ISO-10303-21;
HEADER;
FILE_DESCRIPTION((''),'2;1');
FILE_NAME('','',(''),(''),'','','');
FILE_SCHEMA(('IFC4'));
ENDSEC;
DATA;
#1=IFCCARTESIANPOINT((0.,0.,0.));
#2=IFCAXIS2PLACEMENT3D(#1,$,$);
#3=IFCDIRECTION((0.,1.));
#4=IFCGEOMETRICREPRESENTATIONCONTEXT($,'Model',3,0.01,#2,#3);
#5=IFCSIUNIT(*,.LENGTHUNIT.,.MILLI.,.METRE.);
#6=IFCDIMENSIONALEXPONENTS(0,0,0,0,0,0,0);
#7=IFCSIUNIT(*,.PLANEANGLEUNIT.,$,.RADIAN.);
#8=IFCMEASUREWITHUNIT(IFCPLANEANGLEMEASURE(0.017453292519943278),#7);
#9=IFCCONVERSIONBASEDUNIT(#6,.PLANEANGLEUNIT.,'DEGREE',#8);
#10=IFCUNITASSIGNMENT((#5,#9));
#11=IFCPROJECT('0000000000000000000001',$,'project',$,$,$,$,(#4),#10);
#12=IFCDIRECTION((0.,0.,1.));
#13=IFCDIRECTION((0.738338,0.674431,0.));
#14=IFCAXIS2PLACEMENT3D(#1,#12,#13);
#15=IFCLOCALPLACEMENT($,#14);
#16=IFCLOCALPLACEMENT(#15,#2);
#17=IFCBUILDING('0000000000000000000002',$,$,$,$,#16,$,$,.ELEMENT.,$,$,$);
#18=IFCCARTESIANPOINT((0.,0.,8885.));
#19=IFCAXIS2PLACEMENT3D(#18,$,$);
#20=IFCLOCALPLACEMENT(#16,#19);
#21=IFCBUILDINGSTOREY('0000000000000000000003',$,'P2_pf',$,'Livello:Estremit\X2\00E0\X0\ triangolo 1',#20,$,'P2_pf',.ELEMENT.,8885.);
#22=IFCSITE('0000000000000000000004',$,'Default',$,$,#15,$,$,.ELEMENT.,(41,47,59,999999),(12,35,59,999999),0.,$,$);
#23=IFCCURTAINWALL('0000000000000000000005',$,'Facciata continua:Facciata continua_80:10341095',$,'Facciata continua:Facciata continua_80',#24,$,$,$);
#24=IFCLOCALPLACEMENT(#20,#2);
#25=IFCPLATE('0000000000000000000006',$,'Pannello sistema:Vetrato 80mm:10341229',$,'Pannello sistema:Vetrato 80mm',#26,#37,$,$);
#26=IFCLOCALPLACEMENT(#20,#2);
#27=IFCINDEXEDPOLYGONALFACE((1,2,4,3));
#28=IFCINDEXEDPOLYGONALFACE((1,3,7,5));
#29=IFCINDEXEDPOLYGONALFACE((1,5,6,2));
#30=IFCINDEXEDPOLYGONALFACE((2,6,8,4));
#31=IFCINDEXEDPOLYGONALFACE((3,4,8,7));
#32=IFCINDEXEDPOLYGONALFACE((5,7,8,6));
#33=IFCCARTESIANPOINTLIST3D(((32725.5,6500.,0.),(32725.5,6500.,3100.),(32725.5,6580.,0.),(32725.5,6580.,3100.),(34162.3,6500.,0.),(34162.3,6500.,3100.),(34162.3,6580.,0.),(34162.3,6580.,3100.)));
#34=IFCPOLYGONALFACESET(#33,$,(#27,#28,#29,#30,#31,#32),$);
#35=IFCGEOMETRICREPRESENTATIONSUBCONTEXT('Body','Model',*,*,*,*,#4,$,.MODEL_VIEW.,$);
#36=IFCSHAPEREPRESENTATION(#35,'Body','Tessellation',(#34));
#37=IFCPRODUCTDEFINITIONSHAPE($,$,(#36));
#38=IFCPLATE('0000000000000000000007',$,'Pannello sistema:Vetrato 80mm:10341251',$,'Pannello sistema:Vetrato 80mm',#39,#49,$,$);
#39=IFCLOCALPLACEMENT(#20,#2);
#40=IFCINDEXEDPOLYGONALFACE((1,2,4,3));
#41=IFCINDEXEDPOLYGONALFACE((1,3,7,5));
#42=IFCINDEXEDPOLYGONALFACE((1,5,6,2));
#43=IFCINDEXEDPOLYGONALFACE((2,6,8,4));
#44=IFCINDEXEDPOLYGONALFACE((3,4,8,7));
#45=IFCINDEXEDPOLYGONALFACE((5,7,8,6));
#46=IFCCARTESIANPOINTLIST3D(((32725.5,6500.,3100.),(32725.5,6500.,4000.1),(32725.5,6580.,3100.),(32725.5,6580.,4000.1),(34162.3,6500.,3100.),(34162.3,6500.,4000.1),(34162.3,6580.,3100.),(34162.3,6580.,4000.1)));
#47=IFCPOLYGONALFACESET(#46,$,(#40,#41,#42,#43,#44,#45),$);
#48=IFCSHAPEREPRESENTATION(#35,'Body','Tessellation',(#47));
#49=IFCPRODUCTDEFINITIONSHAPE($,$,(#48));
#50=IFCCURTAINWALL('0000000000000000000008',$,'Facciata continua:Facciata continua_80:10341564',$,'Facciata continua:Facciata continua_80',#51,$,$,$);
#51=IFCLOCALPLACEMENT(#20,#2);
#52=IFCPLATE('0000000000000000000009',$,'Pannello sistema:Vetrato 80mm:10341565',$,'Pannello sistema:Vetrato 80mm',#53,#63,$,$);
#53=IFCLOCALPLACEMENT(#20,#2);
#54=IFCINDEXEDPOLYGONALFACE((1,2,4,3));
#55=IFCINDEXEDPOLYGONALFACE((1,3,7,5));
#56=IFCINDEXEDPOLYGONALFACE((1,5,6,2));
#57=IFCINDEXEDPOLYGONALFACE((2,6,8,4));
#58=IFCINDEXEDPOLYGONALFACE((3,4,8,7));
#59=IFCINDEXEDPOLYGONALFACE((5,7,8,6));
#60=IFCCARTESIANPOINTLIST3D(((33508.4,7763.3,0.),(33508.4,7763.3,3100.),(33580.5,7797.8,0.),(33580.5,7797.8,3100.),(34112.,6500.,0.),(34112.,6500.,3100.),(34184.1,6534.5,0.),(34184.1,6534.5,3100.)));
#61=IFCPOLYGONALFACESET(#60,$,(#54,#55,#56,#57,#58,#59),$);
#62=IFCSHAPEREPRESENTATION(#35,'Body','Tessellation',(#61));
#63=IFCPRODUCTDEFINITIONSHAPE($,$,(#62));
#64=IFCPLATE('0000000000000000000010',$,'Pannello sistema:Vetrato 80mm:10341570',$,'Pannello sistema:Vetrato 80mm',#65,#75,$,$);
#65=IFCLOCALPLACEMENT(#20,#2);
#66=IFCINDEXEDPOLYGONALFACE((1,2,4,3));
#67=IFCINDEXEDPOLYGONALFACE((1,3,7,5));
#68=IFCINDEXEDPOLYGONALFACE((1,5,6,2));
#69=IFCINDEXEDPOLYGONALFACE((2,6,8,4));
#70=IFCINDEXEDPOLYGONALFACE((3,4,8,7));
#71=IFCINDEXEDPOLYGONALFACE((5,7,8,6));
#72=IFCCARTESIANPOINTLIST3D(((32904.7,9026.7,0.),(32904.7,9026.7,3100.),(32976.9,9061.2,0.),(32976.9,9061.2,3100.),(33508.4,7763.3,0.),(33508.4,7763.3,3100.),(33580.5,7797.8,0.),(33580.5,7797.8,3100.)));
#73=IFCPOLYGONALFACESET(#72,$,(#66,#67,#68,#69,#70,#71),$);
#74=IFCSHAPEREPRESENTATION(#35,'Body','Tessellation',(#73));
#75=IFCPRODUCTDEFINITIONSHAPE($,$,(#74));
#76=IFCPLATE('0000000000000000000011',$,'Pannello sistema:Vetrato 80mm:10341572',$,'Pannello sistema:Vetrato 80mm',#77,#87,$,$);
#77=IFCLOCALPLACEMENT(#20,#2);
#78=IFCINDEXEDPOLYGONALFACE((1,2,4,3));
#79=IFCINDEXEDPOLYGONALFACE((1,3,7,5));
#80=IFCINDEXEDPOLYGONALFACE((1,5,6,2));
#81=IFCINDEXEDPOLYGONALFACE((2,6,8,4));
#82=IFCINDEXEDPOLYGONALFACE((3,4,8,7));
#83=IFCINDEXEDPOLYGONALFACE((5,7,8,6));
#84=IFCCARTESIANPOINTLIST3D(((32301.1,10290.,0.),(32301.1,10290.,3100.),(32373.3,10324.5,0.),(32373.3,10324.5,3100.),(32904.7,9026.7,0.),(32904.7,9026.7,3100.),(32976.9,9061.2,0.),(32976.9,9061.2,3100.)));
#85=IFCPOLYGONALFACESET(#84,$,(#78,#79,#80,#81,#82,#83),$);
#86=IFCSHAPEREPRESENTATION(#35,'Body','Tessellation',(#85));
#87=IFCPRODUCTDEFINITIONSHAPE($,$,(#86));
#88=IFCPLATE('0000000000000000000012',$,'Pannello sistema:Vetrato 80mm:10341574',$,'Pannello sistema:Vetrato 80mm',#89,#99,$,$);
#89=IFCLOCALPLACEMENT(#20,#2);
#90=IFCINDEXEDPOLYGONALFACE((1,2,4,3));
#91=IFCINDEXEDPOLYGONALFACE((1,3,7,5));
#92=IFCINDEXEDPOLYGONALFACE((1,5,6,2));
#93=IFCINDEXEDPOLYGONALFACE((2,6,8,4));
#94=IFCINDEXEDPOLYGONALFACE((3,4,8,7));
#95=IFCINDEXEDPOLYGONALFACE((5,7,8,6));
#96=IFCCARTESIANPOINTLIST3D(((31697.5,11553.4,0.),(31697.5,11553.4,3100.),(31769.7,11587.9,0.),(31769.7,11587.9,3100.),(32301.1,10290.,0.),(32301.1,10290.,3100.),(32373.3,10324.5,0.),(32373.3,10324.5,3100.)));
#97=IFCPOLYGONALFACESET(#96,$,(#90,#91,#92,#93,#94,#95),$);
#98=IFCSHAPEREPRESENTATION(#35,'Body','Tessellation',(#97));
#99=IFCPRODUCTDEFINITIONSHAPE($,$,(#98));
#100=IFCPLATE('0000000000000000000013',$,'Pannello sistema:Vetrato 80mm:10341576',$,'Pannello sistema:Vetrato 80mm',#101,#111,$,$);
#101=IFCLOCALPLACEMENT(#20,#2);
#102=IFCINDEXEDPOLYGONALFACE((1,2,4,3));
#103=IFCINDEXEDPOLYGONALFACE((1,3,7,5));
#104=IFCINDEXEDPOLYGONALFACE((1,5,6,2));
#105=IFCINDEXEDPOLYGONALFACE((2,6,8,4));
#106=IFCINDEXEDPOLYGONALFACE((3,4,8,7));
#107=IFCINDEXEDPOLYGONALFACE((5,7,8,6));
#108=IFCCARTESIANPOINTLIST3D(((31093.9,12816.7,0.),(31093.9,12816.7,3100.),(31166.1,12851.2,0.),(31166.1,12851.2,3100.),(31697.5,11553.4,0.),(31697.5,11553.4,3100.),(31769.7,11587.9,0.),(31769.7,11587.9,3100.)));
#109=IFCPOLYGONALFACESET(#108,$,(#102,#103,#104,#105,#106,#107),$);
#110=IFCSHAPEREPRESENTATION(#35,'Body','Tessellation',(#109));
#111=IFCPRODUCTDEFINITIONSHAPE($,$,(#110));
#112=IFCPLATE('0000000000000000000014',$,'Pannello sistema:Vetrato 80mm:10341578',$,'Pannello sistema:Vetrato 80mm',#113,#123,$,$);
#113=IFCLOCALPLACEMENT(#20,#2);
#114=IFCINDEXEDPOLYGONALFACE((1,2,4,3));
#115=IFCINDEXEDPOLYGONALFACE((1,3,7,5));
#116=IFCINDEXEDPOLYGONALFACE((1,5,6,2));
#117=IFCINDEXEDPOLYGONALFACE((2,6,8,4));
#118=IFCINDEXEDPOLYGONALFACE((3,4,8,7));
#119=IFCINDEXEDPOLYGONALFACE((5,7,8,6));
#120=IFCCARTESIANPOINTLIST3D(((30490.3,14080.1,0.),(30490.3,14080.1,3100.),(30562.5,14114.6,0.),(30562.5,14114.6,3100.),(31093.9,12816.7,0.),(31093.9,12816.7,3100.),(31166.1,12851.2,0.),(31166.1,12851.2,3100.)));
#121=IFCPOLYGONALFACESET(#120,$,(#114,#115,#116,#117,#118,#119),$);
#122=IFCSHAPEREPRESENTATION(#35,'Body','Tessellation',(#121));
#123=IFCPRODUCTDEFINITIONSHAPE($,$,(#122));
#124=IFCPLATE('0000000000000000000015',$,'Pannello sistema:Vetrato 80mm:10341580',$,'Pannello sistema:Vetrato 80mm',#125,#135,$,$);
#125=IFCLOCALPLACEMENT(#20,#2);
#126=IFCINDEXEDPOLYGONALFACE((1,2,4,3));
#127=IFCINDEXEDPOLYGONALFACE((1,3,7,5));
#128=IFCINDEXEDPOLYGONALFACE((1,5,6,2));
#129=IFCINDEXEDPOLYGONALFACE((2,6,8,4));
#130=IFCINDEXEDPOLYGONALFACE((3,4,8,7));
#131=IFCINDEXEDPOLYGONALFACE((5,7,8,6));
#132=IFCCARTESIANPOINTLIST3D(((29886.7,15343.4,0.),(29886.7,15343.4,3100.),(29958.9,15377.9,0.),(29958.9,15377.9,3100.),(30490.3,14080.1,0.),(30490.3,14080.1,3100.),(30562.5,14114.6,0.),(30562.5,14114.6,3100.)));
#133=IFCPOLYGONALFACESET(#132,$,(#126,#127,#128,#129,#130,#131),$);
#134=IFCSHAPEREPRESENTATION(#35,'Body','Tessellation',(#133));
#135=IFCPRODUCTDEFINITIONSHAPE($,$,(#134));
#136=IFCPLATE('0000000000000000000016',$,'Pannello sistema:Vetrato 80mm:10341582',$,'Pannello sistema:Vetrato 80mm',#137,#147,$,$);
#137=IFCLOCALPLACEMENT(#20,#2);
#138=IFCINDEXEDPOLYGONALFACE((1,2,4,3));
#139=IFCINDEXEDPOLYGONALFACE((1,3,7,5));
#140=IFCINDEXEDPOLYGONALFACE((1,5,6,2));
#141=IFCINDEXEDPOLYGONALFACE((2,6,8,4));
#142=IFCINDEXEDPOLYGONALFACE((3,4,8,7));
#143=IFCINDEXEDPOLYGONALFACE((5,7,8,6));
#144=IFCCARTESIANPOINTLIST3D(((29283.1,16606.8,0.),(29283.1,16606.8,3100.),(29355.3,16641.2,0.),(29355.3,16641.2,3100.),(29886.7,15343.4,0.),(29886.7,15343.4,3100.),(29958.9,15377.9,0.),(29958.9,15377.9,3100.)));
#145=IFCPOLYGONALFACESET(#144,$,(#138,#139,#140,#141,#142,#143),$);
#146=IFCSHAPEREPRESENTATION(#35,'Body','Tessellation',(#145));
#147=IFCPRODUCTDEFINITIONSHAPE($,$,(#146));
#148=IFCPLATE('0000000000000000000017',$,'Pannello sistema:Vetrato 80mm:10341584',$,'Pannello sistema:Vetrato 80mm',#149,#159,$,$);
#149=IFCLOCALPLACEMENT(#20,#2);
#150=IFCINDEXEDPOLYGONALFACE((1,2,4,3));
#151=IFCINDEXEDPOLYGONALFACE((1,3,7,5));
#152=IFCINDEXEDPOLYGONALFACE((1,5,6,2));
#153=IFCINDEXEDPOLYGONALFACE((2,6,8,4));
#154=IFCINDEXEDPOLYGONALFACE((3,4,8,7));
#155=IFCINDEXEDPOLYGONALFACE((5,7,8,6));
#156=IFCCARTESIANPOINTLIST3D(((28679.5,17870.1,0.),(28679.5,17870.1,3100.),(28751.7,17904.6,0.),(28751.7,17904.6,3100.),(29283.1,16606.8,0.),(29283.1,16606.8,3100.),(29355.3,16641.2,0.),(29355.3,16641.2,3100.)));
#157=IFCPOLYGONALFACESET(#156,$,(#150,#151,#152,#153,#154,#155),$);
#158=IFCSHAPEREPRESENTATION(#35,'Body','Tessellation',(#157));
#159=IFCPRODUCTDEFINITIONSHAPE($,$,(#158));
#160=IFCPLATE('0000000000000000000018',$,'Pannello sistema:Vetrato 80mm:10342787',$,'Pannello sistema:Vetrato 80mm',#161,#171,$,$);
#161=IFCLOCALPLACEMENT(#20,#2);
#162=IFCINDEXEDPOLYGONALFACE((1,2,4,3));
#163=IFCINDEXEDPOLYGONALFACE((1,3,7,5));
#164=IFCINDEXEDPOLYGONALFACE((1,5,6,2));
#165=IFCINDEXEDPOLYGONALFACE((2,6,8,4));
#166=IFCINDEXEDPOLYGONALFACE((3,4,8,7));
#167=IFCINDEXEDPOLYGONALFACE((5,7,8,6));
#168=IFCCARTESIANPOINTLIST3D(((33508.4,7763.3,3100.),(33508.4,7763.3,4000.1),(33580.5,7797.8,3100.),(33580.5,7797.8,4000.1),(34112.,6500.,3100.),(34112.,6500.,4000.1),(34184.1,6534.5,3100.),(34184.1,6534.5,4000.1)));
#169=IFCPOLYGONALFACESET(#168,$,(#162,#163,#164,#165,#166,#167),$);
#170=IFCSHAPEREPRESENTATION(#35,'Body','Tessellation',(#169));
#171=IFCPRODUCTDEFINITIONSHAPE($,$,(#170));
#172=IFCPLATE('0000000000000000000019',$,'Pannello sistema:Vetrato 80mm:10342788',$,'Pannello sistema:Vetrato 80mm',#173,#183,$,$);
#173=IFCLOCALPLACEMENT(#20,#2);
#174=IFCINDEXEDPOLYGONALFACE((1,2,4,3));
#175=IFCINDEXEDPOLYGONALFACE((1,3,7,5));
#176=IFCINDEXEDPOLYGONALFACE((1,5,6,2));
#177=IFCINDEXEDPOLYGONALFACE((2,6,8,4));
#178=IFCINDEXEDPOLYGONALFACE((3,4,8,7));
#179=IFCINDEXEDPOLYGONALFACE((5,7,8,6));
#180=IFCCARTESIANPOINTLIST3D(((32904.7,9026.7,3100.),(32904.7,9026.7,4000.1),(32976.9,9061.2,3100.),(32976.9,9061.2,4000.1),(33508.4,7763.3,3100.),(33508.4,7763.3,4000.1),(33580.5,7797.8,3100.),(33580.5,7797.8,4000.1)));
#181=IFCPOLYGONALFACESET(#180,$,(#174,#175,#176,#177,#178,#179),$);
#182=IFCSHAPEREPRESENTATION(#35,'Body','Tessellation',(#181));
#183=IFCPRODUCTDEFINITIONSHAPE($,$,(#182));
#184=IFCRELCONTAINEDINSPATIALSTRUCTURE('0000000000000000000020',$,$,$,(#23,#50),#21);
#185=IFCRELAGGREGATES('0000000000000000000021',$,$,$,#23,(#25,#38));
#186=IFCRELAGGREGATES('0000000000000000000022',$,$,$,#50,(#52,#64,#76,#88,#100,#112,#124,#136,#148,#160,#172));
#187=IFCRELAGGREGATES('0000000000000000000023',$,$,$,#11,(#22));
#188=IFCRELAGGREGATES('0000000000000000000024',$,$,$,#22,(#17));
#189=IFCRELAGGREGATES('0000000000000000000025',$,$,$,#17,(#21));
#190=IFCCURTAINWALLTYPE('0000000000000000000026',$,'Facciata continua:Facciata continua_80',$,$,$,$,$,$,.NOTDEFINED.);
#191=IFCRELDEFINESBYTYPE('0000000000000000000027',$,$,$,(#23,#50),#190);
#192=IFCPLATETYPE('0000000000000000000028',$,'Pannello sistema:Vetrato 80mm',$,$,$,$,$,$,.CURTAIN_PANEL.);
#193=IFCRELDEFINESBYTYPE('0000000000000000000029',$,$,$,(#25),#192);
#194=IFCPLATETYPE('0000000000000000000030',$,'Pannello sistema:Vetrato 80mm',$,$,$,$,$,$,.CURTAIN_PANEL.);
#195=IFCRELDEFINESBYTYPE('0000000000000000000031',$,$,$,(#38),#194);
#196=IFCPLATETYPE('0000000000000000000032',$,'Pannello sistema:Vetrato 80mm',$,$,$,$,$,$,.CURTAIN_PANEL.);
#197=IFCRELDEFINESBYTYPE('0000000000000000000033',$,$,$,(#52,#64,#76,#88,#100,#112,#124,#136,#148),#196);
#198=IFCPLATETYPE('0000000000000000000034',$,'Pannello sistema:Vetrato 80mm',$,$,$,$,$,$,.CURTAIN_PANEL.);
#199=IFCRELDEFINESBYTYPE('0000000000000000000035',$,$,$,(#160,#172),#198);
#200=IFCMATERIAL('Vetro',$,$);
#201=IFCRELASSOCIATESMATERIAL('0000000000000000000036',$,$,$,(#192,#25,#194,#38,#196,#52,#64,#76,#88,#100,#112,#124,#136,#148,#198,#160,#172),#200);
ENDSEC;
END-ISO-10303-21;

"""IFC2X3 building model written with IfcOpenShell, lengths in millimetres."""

from ifc_helpers import new_model, entity, si_unit, converted_unit, direction, frame, frame_2d, origin, origin_2d_with_axis, place, context, subcontext, project, spatial, rectangle, extrude, source, transform, mapped, material, type_object, type_shapes, element, aggregate, save


model = new_model("IFC2X3")

# Units and contexts
model_context = context("Model", 3, precision=0.01, world=origin(), true_north=direction((0.0, 1.0)))
body_context = subcontext(model_context, "Body", "Model", "MODEL_VIEW")
ifc_project = project(units=[si_unit("LENGTHUNIT", "METRE", prefix="MILLI"), converted_unit("PLANEANGLEUNIT", "DEGREE", entity("IfcPlaneAngleMeasure", 0.017453292519943278), si_unit("PLANEANGLEUNIT", "RADIAN"), dimensions=[0, 0, 0, 0, 0, 0, 0])], contexts=[model_context])

# Site, building, storey
site_placement = place(None, frame((0.0, 0.0, 0.0), z_axis=(0.0, 0.0, 1.0), x_axis=(0.738338, 0.674431, 0.0)))
site = spatial("IfcSite", under=ifc_project, at=site_placement, Name="Default", CompositionType="ELEMENT", RefLatitude=(41, 47, 59, 999999), RefLongitude=(12, 35, 59, 999999), RefElevation=0.0)
building_placement = place(site_placement, origin())
building = spatial("IfcBuilding", under=site, at=building_placement, CompositionType="ELEMENT")
storey_placement = place(building_placement, frame((0.0, 0.0, 8885.0)))
storey = spatial("IfcBuildingStorey", under=building, at=storey_placement, Name="P2_pf", ObjectType="Livello:Estremità triangolo 1", LongName="P2_pf", CompositionType="ELEMENT", Elevation=8885.0)

# Curtain walls, plates
curtain_wall_type = type_object("IfcCurtainWallType", Name="Facciata continua:Facciata continua_80", PredefinedType="NOTDEFINED")
curtain_wall_1_placement = place(storey_placement, frame((0.0, 0.0, -8885.0)))
curtain_wall_1 = element("IfcCurtainWall", 1, at=curtain_wall_1_placement, inside=storey, type_object=curtain_wall_type, Name="Facciata continua:Facciata continua_80:10341095", ObjectType="Facciata continua:Facciata continua_80")
ifc_material_1 = material(Name="Vetro")
plate_type_1 = type_object("IfcPlateType", Name="Pannello sistema:Vetrato 80mm", PredefinedType="CURTAIN_PANEL", material=ifc_material_1)
shared_shape_1 = source(origin(), body_context, "Body", "SweptSolid", [
    extrude(rectangle(XDim=80.0, YDim=1436.8, at=origin_2d_with_axis()), frame((0.0, -40.0, 0.0), z_axis=(0.0, 0.0, 1.0), x_axis=(0.0, 1.0, 0.0)), (0.0, 0.0, 1.0), 3100.0),
])
type_shapes(plate_type_1, [shared_shape_1])
plate_1_placement = place(curtain_wall_1_placement, frame((33443.9, 6580.0, 8885.0)))
plate_1 = element("IfcPlate", 2, at=plate_1_placement, type_object=plate_type_1, material=ifc_material_1, Name="Pannello sistema:Vetrato 80mm:10341229", ObjectType="Pannello sistema:Vetrato 80mm", context=body_context, shape_type="MappedRepresentation", body=[
    mapped(shared_shape_1, transform((0.0, 0.0, 0.0), scale=1.0)),
])
plate_type_2 = type_object("IfcPlateType", Name="Pannello sistema:Vetrato 80mm", PredefinedType="CURTAIN_PANEL", material=ifc_material_1)
shared_shape_2 = source(origin(), body_context, "Body", "SweptSolid", [
    extrude(rectangle(XDim=80.0, YDim=1436.8, at=origin_2d_with_axis()), frame((0.0, -40.0, 0.0), z_axis=(0.0, 0.0, 1.0), x_axis=(0.0, 1.0, 0.0)), (0.0, 0.0, 1.0), 900.1),
])
type_shapes(plate_type_2, [shared_shape_2])
plate_2_placement = place(curtain_wall_1_placement, frame((33443.9, 6580.0, 11985.0)))
plate_2 = element("IfcPlate", 3, at=plate_2_placement, type_object=plate_type_2, material=ifc_material_1, Name="Pannello sistema:Vetrato 80mm:10341251", ObjectType="Pannello sistema:Vetrato 80mm", context=body_context, shape_type="MappedRepresentation", body=[
    mapped(shared_shape_2, transform((0.0, 0.0, 0.0), scale=1.0)),
])
aggregate(curtain_wall_1, [plate_1, plate_2])
curtain_wall_2_placement = place(storey_placement, frame((0.0, 0.0, -8885.0)))
curtain_wall_2 = element("IfcCurtainWall", 4, at=curtain_wall_2_placement, inside=storey, type_object=curtain_wall_type, Name="Facciata continua:Facciata continua_80:10341564", ObjectType="Facciata continua:Facciata continua_80")
plate_type_3 = type_object("IfcPlateType", Name="Pannello sistema:Vetrato 80mm", PredefinedType="CURTAIN_PANEL", material=ifc_material_1)
shared_shape_3 = source(origin(), body_context, "Body", "SweptSolid", [
    extrude(rectangle(XDim=80.0, YDim=1400.1, at=frame_2d((0.0, 0.0), x_axis=(1.0, 0.0))), frame((0.0, -40.0, 0.0), z_axis=(0.0, 0.0, 1.0), x_axis=(0.0, 1.0, 0.0)), (0.0, 0.0, 1.0), 3100.0),
])
type_shapes(plate_type_3, [shared_shape_3])
plate_3_placement = place(curtain_wall_2_placement, frame((33810.2, 7131.7, 8885.0), z_axis=(0.0, 0.0, 1.0), x_axis=(-0.431105, 0.902302, 0.0)))
plate_3 = element("IfcPlate", 5, at=plate_3_placement, type_object=plate_type_3, material=ifc_material_1, Name="Pannello sistema:Vetrato 80mm:10341565", ObjectType="Pannello sistema:Vetrato 80mm", context=body_context, shape_type="MappedRepresentation", body=[
    mapped(shared_shape_3, transform((0.0, 0.0, 0.0), scale=1.0)),
])
plate_4_placement = place(curtain_wall_2_placement, frame((33206.6, 8395.0, 8885.0), z_axis=(0.0, 0.0, 1.0), x_axis=(-0.431105, 0.902302, 0.0)))
plate_4 = element("IfcPlate", 6, at=plate_4_placement, type_object=plate_type_3, material=ifc_material_1, Name="Pannello sistema:Vetrato 80mm:10341570", ObjectType="Pannello sistema:Vetrato 80mm", context=body_context, shape_type="MappedRepresentation", body=[
    mapped(shared_shape_3, transform((0.0, 0.0, 0.0), scale=1.0)),
])
plate_5_placement = place(curtain_wall_2_placement, frame((32602.9, 9658.4, 8885.0), z_axis=(0.0, 0.0, 1.0), x_axis=(-0.431105, 0.902302, 0.0)))
plate_5 = element("IfcPlate", 7, at=plate_5_placement, type_object=plate_type_3, material=ifc_material_1, Name="Pannello sistema:Vetrato 80mm:10341572", ObjectType="Pannello sistema:Vetrato 80mm", context=body_context, shape_type="MappedRepresentation", body=[
    mapped(shared_shape_3, transform((0.0, 0.0, 0.0), scale=1.0)),
])
plate_6_placement = place(curtain_wall_2_placement, frame((31999.3, 10921.7, 8885.0), z_axis=(0.0, 0.0, 1.0), x_axis=(-0.431105, 0.902302, 0.0)))
plate_6 = element("IfcPlate", 8, at=plate_6_placement, type_object=plate_type_3, material=ifc_material_1, Name="Pannello sistema:Vetrato 80mm:10341574", ObjectType="Pannello sistema:Vetrato 80mm", context=body_context, shape_type="MappedRepresentation", body=[
    mapped(shared_shape_3, transform((0.0, 0.0, 0.0), scale=1.0)),
])
plate_7_placement = place(curtain_wall_2_placement, frame((31395.7, 12185.0, 8885.0), z_axis=(0.0, 0.0, 1.0), x_axis=(-0.431105, 0.902302, 0.0)))
plate_7 = element("IfcPlate", 9, at=plate_7_placement, type_object=plate_type_3, material=ifc_material_1, Name="Pannello sistema:Vetrato 80mm:10341576", ObjectType="Pannello sistema:Vetrato 80mm", context=body_context, shape_type="MappedRepresentation", body=[
    mapped(shared_shape_3, transform((0.0, 0.0, 0.0), scale=1.0)),
])
plate_8_placement = place(curtain_wall_2_placement, frame((30792.1, 13448.4, 8885.0), z_axis=(0.0, 0.0, 1.0), x_axis=(-0.431105, 0.902302, 0.0)))
plate_8 = element("IfcPlate", 10, at=plate_8_placement, type_object=plate_type_3, material=ifc_material_1, Name="Pannello sistema:Vetrato 80mm:10341578", ObjectType="Pannello sistema:Vetrato 80mm", context=body_context, shape_type="MappedRepresentation", body=[
    mapped(shared_shape_3, transform((0.0, 0.0, 0.0), scale=1.0)),
])
plate_9_placement = place(curtain_wall_2_placement, frame((30188.5, 14711.7, 8885.0), z_axis=(0.0, 0.0, 1.0), x_axis=(-0.431105, 0.902302, 0.0)))
plate_9 = element("IfcPlate", 11, at=plate_9_placement, type_object=plate_type_3, material=ifc_material_1, Name="Pannello sistema:Vetrato 80mm:10341580", ObjectType="Pannello sistema:Vetrato 80mm", context=body_context, shape_type="MappedRepresentation", body=[
    mapped(shared_shape_3, transform((0.0, 0.0, 0.0), scale=1.0)),
])
plate_10_placement = place(curtain_wall_2_placement, frame((29584.9, 15975.1, 8885.0), z_axis=(0.0, 0.0, 1.0), x_axis=(-0.431105, 0.902302, 0.0)))
plate_10 = element("IfcPlate", 12, at=plate_10_placement, type_object=plate_type_3, material=ifc_material_1, Name="Pannello sistema:Vetrato 80mm:10341582", ObjectType="Pannello sistema:Vetrato 80mm", context=body_context, shape_type="MappedRepresentation", body=[
    mapped(shared_shape_3, transform((0.0, 0.0, 0.0), scale=1.0)),
])
plate_11_placement = place(curtain_wall_2_placement, frame((28981.3, 17238.4, 8885.0), z_axis=(0.0, 0.0, 1.0), x_axis=(-0.431105, 0.902302, 0.0)))
plate_11 = element("IfcPlate", 13, at=plate_11_placement, type_object=plate_type_3, material=ifc_material_1, Name="Pannello sistema:Vetrato 80mm:10341584", ObjectType="Pannello sistema:Vetrato 80mm", context=body_context, shape_type="MappedRepresentation", body=[
    mapped(shared_shape_3, transform((0.0, 0.0, 0.0), scale=1.0)),
])
plate_type_4 = type_object("IfcPlateType", Name="Pannello sistema:Vetrato 80mm", PredefinedType="CURTAIN_PANEL", material=ifc_material_1)
shared_shape_4 = source(origin(), body_context, "Body", "SweptSolid", [
    extrude(rectangle(XDim=80.0, YDim=1400.1, at=frame_2d((0.0, 0.0), x_axis=(1.0, 0.0))), frame((0.0, -40.0, 0.0), z_axis=(0.0, 0.0, 1.0), x_axis=(0.0, 1.0, 0.0)), (0.0, 0.0, 1.0), 900.1),
])
type_shapes(plate_type_4, [shared_shape_4])
plate_12_placement = place(curtain_wall_2_placement, frame((33810.2, 7131.7, 11985.0), z_axis=(0.0, 0.0, 1.0), x_axis=(-0.431105, 0.902302, 0.0)))
plate_12 = element("IfcPlate", 14, at=plate_12_placement, type_object=plate_type_4, material=ifc_material_1, Name="Pannello sistema:Vetrato 80mm:10342787", ObjectType="Pannello sistema:Vetrato 80mm", context=body_context, shape_type="MappedRepresentation", body=[
    mapped(shared_shape_4, transform((0.0, 0.0, 0.0), scale=1.0)),
])
plate_13_placement = place(curtain_wall_2_placement, frame((33206.6, 8395.0, 11985.0), z_axis=(0.0, 0.0, 1.0), x_axis=(-0.431105, 0.902302, 0.0)))
plate_13 = element("IfcPlate", 15, at=plate_13_placement, type_object=plate_type_4, material=ifc_material_1, Name="Pannello sistema:Vetrato 80mm:10342788", ObjectType="Pannello sistema:Vetrato 80mm", context=body_context, shape_type="MappedRepresentation", body=[
    mapped(shared_shape_4, transform((0.0, 0.0, 0.0), scale=1.0)),
])
aggregate(curtain_wall_2, [plate_3, plate_4, plate_5, plate_6, plate_7, plate_8, plate_9, plate_10, plate_11, plate_12, plate_13])

save(model, "model.ifc")
